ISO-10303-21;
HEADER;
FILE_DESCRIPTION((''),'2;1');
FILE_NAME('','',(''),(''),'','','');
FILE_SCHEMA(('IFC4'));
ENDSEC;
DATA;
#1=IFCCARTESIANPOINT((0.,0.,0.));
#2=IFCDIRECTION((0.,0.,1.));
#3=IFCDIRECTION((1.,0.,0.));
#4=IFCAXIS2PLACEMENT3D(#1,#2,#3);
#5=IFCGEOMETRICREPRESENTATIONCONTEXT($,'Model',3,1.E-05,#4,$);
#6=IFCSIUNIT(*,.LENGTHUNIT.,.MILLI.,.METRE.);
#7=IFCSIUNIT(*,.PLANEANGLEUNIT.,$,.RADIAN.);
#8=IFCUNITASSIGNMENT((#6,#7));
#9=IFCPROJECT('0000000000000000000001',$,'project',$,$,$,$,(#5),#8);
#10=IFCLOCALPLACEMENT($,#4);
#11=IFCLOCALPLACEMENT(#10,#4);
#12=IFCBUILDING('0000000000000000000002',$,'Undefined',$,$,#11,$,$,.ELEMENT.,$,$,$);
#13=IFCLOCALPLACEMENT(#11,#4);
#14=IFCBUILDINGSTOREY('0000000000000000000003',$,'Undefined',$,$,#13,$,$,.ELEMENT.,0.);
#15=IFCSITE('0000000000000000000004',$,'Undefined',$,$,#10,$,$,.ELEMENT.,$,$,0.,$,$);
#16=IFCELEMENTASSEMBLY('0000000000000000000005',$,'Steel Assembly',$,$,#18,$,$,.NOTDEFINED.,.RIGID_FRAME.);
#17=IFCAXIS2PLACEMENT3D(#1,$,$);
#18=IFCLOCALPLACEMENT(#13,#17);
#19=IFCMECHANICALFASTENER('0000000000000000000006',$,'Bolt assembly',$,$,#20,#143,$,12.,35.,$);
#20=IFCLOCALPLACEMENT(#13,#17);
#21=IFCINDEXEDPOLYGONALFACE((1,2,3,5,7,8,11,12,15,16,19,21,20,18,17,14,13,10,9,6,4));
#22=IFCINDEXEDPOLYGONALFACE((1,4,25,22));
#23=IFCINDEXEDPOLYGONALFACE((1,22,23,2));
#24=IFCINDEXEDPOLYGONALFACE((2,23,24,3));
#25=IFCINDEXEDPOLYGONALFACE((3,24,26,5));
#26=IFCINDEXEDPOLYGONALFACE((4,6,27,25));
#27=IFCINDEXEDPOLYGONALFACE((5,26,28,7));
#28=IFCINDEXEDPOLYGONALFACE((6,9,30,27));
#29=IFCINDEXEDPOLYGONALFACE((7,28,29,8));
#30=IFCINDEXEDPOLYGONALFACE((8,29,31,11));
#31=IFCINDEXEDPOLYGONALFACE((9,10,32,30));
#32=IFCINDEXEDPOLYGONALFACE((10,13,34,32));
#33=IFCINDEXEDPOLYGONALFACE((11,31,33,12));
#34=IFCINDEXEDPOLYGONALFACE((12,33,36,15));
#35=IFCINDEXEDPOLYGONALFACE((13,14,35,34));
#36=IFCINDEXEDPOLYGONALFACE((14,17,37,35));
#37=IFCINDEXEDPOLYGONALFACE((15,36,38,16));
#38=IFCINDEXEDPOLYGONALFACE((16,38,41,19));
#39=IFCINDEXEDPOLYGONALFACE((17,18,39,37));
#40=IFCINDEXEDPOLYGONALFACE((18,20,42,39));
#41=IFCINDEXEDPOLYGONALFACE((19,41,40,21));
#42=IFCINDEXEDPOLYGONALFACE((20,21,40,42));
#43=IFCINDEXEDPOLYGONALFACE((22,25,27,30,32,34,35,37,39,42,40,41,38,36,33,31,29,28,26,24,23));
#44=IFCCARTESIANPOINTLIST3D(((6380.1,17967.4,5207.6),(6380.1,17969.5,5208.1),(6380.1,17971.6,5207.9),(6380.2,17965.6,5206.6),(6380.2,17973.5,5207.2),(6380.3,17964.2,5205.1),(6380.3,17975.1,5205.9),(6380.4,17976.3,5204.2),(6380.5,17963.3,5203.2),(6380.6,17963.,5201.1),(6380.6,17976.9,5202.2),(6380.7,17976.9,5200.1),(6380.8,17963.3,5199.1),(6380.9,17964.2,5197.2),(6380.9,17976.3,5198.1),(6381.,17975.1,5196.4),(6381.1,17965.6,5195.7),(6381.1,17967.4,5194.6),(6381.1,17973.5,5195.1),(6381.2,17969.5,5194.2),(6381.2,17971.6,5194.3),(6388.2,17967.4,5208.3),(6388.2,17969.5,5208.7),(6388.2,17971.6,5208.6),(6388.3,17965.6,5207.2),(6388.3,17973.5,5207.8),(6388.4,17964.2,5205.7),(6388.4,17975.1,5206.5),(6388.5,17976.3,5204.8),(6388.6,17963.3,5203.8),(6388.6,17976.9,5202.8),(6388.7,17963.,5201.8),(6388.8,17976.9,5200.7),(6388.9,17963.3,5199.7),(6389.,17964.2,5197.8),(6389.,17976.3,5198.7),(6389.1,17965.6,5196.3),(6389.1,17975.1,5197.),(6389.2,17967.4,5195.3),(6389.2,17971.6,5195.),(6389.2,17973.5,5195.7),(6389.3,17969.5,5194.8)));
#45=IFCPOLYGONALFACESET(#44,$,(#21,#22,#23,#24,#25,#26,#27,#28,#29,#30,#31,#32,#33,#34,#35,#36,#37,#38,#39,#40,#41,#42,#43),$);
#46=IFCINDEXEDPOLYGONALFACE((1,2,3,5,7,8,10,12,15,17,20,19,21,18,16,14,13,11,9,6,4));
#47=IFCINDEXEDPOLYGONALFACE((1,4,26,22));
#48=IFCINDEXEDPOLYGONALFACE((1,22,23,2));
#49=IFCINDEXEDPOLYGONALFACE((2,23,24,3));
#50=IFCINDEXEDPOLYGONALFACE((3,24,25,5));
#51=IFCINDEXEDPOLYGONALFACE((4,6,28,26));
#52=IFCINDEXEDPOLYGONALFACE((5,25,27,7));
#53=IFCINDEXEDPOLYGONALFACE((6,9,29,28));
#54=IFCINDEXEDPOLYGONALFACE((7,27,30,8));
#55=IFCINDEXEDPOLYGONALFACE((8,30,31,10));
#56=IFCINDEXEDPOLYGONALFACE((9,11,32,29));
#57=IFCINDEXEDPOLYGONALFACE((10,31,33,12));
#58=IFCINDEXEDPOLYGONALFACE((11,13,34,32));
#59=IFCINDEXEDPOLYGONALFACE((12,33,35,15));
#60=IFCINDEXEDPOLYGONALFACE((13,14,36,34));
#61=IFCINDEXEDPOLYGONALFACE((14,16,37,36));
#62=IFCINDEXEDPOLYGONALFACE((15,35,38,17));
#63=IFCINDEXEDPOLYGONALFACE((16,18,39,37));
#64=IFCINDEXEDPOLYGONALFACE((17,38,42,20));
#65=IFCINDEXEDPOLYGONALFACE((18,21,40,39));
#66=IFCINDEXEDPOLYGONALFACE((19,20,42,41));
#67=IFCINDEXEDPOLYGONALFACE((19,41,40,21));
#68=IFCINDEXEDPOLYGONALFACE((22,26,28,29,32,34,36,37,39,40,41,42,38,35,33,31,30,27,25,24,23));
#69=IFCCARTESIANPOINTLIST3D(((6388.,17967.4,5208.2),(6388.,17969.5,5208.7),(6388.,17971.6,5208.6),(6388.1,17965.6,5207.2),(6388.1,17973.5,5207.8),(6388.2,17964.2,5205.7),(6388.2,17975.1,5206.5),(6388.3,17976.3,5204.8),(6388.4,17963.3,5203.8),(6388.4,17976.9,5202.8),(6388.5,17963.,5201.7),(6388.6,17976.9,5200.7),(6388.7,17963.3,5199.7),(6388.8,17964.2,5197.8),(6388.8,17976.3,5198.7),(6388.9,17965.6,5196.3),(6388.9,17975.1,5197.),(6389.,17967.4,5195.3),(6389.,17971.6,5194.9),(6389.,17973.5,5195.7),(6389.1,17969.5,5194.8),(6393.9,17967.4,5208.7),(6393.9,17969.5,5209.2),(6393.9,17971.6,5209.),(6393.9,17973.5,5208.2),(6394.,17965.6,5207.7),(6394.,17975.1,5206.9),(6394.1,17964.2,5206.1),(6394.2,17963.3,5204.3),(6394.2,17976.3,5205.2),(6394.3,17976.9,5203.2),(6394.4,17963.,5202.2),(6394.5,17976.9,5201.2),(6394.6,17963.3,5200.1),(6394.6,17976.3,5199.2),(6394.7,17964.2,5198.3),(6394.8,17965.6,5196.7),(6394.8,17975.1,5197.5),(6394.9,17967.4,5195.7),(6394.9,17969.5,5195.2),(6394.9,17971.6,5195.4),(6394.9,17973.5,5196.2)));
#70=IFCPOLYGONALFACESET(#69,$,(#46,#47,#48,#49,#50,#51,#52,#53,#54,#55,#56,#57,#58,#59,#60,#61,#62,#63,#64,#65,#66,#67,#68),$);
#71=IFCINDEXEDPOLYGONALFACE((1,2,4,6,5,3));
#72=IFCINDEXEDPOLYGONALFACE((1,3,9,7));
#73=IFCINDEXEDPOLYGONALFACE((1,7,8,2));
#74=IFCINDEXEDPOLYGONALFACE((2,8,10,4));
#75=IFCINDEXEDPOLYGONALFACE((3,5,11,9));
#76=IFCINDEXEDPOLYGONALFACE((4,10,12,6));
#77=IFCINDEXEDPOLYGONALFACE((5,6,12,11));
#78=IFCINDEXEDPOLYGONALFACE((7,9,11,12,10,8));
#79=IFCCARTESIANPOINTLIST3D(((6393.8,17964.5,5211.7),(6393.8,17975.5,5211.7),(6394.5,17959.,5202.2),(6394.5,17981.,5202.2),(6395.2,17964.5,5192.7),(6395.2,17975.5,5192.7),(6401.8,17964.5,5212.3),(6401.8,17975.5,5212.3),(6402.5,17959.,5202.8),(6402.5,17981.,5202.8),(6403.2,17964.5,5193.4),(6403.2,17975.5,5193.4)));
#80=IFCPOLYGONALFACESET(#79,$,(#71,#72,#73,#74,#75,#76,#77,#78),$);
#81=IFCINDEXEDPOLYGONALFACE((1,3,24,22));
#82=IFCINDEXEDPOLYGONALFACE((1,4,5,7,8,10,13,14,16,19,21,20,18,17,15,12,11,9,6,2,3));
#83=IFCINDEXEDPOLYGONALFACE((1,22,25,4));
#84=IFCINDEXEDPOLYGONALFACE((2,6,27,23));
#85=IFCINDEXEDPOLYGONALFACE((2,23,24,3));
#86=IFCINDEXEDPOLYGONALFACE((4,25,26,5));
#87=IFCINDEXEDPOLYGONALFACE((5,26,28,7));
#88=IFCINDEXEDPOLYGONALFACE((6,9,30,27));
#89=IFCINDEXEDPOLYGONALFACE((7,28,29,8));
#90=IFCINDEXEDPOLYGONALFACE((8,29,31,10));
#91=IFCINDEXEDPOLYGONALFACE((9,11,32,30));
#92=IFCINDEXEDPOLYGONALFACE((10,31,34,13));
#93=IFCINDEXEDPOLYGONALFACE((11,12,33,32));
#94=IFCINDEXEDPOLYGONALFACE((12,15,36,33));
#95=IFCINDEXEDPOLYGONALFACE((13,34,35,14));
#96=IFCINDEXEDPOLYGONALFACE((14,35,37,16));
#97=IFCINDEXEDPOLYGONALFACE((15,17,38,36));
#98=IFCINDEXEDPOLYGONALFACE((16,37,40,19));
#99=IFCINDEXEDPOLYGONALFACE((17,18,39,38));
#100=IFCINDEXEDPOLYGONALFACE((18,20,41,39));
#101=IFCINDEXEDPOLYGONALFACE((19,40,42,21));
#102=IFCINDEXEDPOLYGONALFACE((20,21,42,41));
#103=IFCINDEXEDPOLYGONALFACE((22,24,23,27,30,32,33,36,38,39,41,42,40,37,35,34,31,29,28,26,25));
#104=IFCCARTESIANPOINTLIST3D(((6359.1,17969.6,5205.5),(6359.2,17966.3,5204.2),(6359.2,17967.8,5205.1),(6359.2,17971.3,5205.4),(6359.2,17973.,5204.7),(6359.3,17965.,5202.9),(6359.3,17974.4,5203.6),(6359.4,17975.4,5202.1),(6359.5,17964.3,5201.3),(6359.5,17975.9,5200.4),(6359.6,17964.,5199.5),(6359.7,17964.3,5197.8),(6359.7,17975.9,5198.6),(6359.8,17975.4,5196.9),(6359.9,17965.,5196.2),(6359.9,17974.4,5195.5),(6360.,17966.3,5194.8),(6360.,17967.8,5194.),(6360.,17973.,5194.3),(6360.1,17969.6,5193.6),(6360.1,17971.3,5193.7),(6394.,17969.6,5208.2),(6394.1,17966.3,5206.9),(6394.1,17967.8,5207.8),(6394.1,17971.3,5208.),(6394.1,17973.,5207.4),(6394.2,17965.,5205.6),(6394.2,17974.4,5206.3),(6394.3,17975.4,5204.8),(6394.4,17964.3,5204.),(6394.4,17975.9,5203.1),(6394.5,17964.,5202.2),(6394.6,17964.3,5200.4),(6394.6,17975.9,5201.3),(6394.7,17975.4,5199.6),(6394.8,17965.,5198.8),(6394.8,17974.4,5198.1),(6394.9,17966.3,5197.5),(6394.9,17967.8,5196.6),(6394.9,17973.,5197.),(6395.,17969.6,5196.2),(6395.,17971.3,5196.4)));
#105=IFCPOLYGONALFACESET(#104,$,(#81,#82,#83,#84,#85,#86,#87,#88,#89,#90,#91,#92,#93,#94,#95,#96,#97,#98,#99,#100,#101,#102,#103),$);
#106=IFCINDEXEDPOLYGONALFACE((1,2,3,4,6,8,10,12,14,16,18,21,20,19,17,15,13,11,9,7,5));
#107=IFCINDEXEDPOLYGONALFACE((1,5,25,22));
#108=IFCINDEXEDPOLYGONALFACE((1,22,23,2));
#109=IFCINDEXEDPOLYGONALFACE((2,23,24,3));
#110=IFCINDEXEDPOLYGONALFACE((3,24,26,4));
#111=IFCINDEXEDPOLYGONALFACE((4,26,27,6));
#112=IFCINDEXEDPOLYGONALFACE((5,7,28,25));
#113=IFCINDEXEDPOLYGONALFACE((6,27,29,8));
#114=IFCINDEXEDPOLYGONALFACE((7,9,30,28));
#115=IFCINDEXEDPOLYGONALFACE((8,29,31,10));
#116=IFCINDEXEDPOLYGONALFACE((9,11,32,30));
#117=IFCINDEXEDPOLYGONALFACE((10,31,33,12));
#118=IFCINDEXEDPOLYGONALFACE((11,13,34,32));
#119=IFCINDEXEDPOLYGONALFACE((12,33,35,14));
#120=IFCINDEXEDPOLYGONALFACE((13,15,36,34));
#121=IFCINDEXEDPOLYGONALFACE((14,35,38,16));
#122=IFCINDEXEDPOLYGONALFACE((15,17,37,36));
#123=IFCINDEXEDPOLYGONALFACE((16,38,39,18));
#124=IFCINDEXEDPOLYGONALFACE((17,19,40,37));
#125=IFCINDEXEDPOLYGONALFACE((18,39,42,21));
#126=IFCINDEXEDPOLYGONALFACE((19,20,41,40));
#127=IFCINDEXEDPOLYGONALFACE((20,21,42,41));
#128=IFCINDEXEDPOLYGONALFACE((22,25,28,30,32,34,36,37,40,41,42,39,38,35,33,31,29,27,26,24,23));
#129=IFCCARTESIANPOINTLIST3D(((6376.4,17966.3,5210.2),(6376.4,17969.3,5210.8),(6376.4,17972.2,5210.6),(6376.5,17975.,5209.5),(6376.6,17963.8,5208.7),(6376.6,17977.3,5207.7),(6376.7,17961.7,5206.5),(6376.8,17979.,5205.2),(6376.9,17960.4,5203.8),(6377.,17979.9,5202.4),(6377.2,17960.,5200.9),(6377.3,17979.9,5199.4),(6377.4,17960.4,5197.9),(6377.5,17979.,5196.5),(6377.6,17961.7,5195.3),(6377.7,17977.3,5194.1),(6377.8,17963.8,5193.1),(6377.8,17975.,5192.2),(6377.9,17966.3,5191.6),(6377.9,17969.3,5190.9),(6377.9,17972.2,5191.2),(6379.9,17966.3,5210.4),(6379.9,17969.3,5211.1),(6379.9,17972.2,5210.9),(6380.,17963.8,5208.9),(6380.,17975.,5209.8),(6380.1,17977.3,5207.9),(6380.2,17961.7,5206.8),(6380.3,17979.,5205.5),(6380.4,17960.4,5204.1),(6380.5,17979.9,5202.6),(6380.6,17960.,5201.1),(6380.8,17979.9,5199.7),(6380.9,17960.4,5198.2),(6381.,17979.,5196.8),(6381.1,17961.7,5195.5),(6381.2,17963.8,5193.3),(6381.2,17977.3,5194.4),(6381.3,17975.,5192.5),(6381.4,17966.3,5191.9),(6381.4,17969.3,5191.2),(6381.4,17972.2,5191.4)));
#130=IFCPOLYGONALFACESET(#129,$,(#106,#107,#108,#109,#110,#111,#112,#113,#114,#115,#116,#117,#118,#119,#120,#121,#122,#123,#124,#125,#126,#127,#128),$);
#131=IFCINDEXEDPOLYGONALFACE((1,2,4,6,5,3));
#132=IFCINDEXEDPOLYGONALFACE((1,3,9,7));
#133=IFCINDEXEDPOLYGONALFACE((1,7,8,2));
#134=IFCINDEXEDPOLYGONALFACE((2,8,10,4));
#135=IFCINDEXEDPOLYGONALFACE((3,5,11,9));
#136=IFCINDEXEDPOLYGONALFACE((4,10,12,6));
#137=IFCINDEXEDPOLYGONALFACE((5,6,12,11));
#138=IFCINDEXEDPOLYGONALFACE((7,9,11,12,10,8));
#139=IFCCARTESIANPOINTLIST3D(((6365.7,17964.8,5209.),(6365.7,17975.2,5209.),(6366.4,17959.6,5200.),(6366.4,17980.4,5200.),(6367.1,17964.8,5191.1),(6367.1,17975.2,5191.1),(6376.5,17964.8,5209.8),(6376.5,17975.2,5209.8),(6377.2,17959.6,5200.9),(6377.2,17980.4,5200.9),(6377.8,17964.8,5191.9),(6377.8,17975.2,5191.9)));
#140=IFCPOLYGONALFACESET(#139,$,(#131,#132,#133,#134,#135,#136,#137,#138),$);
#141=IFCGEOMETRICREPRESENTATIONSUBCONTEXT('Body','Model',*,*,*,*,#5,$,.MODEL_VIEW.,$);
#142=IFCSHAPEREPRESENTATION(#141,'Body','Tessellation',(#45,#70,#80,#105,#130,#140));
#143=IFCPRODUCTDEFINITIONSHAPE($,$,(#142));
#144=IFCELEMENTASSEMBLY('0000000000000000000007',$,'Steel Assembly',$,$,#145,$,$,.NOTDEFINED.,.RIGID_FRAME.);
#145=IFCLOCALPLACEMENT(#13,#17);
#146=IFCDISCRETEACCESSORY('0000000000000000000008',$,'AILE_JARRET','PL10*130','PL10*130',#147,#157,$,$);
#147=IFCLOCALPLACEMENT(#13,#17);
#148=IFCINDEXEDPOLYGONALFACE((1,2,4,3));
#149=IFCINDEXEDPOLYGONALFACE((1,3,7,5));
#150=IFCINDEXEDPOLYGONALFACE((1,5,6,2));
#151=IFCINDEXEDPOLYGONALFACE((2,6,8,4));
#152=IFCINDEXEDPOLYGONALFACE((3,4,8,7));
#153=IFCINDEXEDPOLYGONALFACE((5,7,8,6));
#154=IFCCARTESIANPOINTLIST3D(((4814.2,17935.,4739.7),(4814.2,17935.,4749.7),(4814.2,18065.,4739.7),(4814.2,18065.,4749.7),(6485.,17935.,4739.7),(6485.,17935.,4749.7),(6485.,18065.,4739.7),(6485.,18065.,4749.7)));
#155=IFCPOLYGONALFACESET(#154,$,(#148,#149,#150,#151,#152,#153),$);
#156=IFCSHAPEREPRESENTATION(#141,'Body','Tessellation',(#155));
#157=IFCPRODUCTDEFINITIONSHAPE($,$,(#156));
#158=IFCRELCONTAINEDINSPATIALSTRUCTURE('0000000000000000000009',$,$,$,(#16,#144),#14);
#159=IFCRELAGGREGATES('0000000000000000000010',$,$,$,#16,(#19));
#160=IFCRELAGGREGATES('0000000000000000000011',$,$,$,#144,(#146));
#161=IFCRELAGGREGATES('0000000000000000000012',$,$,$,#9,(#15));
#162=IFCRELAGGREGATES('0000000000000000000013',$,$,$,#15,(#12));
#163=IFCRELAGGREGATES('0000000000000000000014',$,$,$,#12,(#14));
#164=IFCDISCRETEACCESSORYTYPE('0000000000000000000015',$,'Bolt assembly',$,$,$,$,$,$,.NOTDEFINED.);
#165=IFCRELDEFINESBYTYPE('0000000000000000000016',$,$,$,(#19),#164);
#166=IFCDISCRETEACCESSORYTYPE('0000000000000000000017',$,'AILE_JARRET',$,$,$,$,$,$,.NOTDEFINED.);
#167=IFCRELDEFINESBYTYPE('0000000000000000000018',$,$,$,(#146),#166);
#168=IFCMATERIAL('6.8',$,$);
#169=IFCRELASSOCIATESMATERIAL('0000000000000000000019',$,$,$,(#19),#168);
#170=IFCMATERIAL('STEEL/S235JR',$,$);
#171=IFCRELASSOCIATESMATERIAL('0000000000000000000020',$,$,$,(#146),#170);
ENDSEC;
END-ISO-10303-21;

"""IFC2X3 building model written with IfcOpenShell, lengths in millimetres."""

from ifc_helpers import new_model, si_unit, frame, origin_with_axes, origin_2d_with_axis, place, context, subcontext, project, spatial, polyline, circle, outline, extrude, source, transform, mapped, material, type_object, element, aggregate, save


model = new_model("IFC2X3")

# Units and contexts
model_context = context("Model", 3, precision=1e-05, world=origin_with_axes())
body_context = subcontext(model_context, "Body", "Model", "MODEL_VIEW")
ifc_project = project(units=[si_unit("LENGTHUNIT", "METRE", prefix="MILLI"), si_unit("PLANEANGLEUNIT", "RADIAN")], contexts=[model_context])

# Site, building, storey
site_placement = place(None, origin_with_axes())
site = spatial("IfcSite", under=ifc_project, at=site_placement, Name="Undefined", CompositionType="ELEMENT", RefElevation=0.0)
building_placement = place(site_placement, origin_with_axes())
building = spatial("IfcBuilding", under=site, at=building_placement, Name="Undefined", CompositionType="ELEMENT")
storey_placement = place(building_placement, origin_with_axes())
storey = spatial("IfcBuildingStorey", under=building, at=storey_placement, Name="Undefined", CompositionType="ELEMENT", Elevation=0.0)

# Element assembly
ifc_material_1 = material(Name="STEEL/S235JR")
assembly_1_placement = place(storey_placement, origin_with_axes())
assembly_1 = element("IfcElementAssembly", 1, at=assembly_1_placement, inside=storey, Name="Steel Assembly", AssemblyPlace="NOTDEFINED", PredefinedType="RIGID_FRAME")

# Shared definitions
ifc_material_2 = material(Name="6.8")
discrete_accessory_type_1 = type_object("IfcDiscreteAccessoryType", Name="Bolt assembly")

# Mechanical fastener
shared_shape_1 = source(origin_with_axes(), body_context, "Body", "SweptSolid", [
    extrude(circle(Radius=7.0, at=origin_2d_with_axis()), frame((0.0, 2.9, 0.0), z_axis=(0.0, 1.0, 0.0), x_axis=(1.0, 0.0, 0.0)), (0.0, 0.0, 1.0), 8.1),
    extrude(circle(Radius=7.0, at=origin_2d_with_axis()), frame((0.0, -2.9, 0.0), z_axis=(0.0, 1.0, 0.0), x_axis=(1.0, 0.0, 0.0)), (0.0, 0.0, 1.0), 5.9),
    extrude(outline(polyline([(11.0, 0.0), (5.5, 9.5), (-5.5, 9.5), (-11.0, 0.0), (-5.5, -9.5), (5.5, -9.5), (11.0, 0.0)])), frame((0.0, -11.0, 0.0), z_axis=(0.0, 1.0, 0.0), x_axis=(1.0, 0.0, 0.0)), (0.0, 0.0, 1.0), 8.0),
    extrude(circle(Radius=6.0, at=origin_2d_with_axis()), frame((0.0, -3.0, 0.0), z_axis=(0.0, 1.0, 0.0), x_axis=(1.0, 0.0, 0.0)), (0.0, 0.0, 1.0), 35.0),
    extrude(circle(Radius=10.0, at=origin_2d_with_axis()), frame((0.0, 11.0, 0.0), z_axis=(0.0, 1.0, 0.0), x_axis=(1.0, 0.0, 0.0)), (0.0, 0.0, 1.0), 3.5),
    extrude(outline(polyline([(10.4, 0.0), (5.2, 9.0), (-5.2, 9.0), (-10.4, 0.0), (-5.2, -9.0), (5.2, -9.0), (10.4, 0.0)])), frame((0.0, 14.5, 0.0), z_axis=(0.0, 1.0, 0.0), x_axis=(1.0, 0.0, 0.0)), (0.0, 0.0, 1.0), 10.8),
])
mechanical_fastener_1_placement = place(assembly_1_placement, frame((6391.6, 17970.0, 5202.0), z_axis=(0.076696, 0.0, -0.997054), x_axis=(0.0, -1.0, 0.0)))
mechanical_fastener_1 = element("IfcMechanicalFastener", 2, at=mechanical_fastener_1_placement, type_object=discrete_accessory_type_1, material=ifc_material_2, Name="Bolt assembly", NominalDiameter=12.0, NominalLength=35.0, context=body_context, shape_type="MappedRepresentation", body=[
    mapped(shared_shape_1, transform((0.0, 0.0, 0.0))),
])
aggregate(assembly_1, [mechanical_fastener_1])

# Element assembly, discrete accessory
assembly_2_placement = place(storey_placement, origin_with_axes())
assembly_2 = element("IfcElementAssembly", 3, at=assembly_2_placement, inside=storey, Name="Steel Assembly", AssemblyPlace="NOTDEFINED", PredefinedType="RIGID_FRAME")
discrete_accessory_type_2 = type_object("IfcDiscreteAccessoryType", Name="AILE_JARRET")
discrete_accessory_1_placement = place(assembly_2_placement, frame((4814.2, 18000.0, 4744.7), z_axis=(0.0, 0.0, -1.0), x_axis=(1.0, 0.0, 0.0)))
discrete_accessory_1 = element("IfcDiscreteAccessory", 4, at=discrete_accessory_1_placement, type_object=discrete_accessory_type_2, material=ifc_material_1, Name="AILE_JARRET", Description="PL10*130", ObjectType="PL10*130", context=body_context, shape_type="SweptSolid", body=[
    extrude(outline(polyline([(0.0, 65.0), (1670.8, 65.0), (1670.8, -65.0), (0.0, -65.0), (0.0, 65.0)])), frame((0.0, 0.0, -5.0), z_axis=(0.0, 0.0, 1.0), x_axis=(1.0, 0.0, 0.0)), (0.0, 0.0, 1.0), 10.0),
])
aggregate(assembly_2, [discrete_accessory_1])

save(model, "model.ifc")
